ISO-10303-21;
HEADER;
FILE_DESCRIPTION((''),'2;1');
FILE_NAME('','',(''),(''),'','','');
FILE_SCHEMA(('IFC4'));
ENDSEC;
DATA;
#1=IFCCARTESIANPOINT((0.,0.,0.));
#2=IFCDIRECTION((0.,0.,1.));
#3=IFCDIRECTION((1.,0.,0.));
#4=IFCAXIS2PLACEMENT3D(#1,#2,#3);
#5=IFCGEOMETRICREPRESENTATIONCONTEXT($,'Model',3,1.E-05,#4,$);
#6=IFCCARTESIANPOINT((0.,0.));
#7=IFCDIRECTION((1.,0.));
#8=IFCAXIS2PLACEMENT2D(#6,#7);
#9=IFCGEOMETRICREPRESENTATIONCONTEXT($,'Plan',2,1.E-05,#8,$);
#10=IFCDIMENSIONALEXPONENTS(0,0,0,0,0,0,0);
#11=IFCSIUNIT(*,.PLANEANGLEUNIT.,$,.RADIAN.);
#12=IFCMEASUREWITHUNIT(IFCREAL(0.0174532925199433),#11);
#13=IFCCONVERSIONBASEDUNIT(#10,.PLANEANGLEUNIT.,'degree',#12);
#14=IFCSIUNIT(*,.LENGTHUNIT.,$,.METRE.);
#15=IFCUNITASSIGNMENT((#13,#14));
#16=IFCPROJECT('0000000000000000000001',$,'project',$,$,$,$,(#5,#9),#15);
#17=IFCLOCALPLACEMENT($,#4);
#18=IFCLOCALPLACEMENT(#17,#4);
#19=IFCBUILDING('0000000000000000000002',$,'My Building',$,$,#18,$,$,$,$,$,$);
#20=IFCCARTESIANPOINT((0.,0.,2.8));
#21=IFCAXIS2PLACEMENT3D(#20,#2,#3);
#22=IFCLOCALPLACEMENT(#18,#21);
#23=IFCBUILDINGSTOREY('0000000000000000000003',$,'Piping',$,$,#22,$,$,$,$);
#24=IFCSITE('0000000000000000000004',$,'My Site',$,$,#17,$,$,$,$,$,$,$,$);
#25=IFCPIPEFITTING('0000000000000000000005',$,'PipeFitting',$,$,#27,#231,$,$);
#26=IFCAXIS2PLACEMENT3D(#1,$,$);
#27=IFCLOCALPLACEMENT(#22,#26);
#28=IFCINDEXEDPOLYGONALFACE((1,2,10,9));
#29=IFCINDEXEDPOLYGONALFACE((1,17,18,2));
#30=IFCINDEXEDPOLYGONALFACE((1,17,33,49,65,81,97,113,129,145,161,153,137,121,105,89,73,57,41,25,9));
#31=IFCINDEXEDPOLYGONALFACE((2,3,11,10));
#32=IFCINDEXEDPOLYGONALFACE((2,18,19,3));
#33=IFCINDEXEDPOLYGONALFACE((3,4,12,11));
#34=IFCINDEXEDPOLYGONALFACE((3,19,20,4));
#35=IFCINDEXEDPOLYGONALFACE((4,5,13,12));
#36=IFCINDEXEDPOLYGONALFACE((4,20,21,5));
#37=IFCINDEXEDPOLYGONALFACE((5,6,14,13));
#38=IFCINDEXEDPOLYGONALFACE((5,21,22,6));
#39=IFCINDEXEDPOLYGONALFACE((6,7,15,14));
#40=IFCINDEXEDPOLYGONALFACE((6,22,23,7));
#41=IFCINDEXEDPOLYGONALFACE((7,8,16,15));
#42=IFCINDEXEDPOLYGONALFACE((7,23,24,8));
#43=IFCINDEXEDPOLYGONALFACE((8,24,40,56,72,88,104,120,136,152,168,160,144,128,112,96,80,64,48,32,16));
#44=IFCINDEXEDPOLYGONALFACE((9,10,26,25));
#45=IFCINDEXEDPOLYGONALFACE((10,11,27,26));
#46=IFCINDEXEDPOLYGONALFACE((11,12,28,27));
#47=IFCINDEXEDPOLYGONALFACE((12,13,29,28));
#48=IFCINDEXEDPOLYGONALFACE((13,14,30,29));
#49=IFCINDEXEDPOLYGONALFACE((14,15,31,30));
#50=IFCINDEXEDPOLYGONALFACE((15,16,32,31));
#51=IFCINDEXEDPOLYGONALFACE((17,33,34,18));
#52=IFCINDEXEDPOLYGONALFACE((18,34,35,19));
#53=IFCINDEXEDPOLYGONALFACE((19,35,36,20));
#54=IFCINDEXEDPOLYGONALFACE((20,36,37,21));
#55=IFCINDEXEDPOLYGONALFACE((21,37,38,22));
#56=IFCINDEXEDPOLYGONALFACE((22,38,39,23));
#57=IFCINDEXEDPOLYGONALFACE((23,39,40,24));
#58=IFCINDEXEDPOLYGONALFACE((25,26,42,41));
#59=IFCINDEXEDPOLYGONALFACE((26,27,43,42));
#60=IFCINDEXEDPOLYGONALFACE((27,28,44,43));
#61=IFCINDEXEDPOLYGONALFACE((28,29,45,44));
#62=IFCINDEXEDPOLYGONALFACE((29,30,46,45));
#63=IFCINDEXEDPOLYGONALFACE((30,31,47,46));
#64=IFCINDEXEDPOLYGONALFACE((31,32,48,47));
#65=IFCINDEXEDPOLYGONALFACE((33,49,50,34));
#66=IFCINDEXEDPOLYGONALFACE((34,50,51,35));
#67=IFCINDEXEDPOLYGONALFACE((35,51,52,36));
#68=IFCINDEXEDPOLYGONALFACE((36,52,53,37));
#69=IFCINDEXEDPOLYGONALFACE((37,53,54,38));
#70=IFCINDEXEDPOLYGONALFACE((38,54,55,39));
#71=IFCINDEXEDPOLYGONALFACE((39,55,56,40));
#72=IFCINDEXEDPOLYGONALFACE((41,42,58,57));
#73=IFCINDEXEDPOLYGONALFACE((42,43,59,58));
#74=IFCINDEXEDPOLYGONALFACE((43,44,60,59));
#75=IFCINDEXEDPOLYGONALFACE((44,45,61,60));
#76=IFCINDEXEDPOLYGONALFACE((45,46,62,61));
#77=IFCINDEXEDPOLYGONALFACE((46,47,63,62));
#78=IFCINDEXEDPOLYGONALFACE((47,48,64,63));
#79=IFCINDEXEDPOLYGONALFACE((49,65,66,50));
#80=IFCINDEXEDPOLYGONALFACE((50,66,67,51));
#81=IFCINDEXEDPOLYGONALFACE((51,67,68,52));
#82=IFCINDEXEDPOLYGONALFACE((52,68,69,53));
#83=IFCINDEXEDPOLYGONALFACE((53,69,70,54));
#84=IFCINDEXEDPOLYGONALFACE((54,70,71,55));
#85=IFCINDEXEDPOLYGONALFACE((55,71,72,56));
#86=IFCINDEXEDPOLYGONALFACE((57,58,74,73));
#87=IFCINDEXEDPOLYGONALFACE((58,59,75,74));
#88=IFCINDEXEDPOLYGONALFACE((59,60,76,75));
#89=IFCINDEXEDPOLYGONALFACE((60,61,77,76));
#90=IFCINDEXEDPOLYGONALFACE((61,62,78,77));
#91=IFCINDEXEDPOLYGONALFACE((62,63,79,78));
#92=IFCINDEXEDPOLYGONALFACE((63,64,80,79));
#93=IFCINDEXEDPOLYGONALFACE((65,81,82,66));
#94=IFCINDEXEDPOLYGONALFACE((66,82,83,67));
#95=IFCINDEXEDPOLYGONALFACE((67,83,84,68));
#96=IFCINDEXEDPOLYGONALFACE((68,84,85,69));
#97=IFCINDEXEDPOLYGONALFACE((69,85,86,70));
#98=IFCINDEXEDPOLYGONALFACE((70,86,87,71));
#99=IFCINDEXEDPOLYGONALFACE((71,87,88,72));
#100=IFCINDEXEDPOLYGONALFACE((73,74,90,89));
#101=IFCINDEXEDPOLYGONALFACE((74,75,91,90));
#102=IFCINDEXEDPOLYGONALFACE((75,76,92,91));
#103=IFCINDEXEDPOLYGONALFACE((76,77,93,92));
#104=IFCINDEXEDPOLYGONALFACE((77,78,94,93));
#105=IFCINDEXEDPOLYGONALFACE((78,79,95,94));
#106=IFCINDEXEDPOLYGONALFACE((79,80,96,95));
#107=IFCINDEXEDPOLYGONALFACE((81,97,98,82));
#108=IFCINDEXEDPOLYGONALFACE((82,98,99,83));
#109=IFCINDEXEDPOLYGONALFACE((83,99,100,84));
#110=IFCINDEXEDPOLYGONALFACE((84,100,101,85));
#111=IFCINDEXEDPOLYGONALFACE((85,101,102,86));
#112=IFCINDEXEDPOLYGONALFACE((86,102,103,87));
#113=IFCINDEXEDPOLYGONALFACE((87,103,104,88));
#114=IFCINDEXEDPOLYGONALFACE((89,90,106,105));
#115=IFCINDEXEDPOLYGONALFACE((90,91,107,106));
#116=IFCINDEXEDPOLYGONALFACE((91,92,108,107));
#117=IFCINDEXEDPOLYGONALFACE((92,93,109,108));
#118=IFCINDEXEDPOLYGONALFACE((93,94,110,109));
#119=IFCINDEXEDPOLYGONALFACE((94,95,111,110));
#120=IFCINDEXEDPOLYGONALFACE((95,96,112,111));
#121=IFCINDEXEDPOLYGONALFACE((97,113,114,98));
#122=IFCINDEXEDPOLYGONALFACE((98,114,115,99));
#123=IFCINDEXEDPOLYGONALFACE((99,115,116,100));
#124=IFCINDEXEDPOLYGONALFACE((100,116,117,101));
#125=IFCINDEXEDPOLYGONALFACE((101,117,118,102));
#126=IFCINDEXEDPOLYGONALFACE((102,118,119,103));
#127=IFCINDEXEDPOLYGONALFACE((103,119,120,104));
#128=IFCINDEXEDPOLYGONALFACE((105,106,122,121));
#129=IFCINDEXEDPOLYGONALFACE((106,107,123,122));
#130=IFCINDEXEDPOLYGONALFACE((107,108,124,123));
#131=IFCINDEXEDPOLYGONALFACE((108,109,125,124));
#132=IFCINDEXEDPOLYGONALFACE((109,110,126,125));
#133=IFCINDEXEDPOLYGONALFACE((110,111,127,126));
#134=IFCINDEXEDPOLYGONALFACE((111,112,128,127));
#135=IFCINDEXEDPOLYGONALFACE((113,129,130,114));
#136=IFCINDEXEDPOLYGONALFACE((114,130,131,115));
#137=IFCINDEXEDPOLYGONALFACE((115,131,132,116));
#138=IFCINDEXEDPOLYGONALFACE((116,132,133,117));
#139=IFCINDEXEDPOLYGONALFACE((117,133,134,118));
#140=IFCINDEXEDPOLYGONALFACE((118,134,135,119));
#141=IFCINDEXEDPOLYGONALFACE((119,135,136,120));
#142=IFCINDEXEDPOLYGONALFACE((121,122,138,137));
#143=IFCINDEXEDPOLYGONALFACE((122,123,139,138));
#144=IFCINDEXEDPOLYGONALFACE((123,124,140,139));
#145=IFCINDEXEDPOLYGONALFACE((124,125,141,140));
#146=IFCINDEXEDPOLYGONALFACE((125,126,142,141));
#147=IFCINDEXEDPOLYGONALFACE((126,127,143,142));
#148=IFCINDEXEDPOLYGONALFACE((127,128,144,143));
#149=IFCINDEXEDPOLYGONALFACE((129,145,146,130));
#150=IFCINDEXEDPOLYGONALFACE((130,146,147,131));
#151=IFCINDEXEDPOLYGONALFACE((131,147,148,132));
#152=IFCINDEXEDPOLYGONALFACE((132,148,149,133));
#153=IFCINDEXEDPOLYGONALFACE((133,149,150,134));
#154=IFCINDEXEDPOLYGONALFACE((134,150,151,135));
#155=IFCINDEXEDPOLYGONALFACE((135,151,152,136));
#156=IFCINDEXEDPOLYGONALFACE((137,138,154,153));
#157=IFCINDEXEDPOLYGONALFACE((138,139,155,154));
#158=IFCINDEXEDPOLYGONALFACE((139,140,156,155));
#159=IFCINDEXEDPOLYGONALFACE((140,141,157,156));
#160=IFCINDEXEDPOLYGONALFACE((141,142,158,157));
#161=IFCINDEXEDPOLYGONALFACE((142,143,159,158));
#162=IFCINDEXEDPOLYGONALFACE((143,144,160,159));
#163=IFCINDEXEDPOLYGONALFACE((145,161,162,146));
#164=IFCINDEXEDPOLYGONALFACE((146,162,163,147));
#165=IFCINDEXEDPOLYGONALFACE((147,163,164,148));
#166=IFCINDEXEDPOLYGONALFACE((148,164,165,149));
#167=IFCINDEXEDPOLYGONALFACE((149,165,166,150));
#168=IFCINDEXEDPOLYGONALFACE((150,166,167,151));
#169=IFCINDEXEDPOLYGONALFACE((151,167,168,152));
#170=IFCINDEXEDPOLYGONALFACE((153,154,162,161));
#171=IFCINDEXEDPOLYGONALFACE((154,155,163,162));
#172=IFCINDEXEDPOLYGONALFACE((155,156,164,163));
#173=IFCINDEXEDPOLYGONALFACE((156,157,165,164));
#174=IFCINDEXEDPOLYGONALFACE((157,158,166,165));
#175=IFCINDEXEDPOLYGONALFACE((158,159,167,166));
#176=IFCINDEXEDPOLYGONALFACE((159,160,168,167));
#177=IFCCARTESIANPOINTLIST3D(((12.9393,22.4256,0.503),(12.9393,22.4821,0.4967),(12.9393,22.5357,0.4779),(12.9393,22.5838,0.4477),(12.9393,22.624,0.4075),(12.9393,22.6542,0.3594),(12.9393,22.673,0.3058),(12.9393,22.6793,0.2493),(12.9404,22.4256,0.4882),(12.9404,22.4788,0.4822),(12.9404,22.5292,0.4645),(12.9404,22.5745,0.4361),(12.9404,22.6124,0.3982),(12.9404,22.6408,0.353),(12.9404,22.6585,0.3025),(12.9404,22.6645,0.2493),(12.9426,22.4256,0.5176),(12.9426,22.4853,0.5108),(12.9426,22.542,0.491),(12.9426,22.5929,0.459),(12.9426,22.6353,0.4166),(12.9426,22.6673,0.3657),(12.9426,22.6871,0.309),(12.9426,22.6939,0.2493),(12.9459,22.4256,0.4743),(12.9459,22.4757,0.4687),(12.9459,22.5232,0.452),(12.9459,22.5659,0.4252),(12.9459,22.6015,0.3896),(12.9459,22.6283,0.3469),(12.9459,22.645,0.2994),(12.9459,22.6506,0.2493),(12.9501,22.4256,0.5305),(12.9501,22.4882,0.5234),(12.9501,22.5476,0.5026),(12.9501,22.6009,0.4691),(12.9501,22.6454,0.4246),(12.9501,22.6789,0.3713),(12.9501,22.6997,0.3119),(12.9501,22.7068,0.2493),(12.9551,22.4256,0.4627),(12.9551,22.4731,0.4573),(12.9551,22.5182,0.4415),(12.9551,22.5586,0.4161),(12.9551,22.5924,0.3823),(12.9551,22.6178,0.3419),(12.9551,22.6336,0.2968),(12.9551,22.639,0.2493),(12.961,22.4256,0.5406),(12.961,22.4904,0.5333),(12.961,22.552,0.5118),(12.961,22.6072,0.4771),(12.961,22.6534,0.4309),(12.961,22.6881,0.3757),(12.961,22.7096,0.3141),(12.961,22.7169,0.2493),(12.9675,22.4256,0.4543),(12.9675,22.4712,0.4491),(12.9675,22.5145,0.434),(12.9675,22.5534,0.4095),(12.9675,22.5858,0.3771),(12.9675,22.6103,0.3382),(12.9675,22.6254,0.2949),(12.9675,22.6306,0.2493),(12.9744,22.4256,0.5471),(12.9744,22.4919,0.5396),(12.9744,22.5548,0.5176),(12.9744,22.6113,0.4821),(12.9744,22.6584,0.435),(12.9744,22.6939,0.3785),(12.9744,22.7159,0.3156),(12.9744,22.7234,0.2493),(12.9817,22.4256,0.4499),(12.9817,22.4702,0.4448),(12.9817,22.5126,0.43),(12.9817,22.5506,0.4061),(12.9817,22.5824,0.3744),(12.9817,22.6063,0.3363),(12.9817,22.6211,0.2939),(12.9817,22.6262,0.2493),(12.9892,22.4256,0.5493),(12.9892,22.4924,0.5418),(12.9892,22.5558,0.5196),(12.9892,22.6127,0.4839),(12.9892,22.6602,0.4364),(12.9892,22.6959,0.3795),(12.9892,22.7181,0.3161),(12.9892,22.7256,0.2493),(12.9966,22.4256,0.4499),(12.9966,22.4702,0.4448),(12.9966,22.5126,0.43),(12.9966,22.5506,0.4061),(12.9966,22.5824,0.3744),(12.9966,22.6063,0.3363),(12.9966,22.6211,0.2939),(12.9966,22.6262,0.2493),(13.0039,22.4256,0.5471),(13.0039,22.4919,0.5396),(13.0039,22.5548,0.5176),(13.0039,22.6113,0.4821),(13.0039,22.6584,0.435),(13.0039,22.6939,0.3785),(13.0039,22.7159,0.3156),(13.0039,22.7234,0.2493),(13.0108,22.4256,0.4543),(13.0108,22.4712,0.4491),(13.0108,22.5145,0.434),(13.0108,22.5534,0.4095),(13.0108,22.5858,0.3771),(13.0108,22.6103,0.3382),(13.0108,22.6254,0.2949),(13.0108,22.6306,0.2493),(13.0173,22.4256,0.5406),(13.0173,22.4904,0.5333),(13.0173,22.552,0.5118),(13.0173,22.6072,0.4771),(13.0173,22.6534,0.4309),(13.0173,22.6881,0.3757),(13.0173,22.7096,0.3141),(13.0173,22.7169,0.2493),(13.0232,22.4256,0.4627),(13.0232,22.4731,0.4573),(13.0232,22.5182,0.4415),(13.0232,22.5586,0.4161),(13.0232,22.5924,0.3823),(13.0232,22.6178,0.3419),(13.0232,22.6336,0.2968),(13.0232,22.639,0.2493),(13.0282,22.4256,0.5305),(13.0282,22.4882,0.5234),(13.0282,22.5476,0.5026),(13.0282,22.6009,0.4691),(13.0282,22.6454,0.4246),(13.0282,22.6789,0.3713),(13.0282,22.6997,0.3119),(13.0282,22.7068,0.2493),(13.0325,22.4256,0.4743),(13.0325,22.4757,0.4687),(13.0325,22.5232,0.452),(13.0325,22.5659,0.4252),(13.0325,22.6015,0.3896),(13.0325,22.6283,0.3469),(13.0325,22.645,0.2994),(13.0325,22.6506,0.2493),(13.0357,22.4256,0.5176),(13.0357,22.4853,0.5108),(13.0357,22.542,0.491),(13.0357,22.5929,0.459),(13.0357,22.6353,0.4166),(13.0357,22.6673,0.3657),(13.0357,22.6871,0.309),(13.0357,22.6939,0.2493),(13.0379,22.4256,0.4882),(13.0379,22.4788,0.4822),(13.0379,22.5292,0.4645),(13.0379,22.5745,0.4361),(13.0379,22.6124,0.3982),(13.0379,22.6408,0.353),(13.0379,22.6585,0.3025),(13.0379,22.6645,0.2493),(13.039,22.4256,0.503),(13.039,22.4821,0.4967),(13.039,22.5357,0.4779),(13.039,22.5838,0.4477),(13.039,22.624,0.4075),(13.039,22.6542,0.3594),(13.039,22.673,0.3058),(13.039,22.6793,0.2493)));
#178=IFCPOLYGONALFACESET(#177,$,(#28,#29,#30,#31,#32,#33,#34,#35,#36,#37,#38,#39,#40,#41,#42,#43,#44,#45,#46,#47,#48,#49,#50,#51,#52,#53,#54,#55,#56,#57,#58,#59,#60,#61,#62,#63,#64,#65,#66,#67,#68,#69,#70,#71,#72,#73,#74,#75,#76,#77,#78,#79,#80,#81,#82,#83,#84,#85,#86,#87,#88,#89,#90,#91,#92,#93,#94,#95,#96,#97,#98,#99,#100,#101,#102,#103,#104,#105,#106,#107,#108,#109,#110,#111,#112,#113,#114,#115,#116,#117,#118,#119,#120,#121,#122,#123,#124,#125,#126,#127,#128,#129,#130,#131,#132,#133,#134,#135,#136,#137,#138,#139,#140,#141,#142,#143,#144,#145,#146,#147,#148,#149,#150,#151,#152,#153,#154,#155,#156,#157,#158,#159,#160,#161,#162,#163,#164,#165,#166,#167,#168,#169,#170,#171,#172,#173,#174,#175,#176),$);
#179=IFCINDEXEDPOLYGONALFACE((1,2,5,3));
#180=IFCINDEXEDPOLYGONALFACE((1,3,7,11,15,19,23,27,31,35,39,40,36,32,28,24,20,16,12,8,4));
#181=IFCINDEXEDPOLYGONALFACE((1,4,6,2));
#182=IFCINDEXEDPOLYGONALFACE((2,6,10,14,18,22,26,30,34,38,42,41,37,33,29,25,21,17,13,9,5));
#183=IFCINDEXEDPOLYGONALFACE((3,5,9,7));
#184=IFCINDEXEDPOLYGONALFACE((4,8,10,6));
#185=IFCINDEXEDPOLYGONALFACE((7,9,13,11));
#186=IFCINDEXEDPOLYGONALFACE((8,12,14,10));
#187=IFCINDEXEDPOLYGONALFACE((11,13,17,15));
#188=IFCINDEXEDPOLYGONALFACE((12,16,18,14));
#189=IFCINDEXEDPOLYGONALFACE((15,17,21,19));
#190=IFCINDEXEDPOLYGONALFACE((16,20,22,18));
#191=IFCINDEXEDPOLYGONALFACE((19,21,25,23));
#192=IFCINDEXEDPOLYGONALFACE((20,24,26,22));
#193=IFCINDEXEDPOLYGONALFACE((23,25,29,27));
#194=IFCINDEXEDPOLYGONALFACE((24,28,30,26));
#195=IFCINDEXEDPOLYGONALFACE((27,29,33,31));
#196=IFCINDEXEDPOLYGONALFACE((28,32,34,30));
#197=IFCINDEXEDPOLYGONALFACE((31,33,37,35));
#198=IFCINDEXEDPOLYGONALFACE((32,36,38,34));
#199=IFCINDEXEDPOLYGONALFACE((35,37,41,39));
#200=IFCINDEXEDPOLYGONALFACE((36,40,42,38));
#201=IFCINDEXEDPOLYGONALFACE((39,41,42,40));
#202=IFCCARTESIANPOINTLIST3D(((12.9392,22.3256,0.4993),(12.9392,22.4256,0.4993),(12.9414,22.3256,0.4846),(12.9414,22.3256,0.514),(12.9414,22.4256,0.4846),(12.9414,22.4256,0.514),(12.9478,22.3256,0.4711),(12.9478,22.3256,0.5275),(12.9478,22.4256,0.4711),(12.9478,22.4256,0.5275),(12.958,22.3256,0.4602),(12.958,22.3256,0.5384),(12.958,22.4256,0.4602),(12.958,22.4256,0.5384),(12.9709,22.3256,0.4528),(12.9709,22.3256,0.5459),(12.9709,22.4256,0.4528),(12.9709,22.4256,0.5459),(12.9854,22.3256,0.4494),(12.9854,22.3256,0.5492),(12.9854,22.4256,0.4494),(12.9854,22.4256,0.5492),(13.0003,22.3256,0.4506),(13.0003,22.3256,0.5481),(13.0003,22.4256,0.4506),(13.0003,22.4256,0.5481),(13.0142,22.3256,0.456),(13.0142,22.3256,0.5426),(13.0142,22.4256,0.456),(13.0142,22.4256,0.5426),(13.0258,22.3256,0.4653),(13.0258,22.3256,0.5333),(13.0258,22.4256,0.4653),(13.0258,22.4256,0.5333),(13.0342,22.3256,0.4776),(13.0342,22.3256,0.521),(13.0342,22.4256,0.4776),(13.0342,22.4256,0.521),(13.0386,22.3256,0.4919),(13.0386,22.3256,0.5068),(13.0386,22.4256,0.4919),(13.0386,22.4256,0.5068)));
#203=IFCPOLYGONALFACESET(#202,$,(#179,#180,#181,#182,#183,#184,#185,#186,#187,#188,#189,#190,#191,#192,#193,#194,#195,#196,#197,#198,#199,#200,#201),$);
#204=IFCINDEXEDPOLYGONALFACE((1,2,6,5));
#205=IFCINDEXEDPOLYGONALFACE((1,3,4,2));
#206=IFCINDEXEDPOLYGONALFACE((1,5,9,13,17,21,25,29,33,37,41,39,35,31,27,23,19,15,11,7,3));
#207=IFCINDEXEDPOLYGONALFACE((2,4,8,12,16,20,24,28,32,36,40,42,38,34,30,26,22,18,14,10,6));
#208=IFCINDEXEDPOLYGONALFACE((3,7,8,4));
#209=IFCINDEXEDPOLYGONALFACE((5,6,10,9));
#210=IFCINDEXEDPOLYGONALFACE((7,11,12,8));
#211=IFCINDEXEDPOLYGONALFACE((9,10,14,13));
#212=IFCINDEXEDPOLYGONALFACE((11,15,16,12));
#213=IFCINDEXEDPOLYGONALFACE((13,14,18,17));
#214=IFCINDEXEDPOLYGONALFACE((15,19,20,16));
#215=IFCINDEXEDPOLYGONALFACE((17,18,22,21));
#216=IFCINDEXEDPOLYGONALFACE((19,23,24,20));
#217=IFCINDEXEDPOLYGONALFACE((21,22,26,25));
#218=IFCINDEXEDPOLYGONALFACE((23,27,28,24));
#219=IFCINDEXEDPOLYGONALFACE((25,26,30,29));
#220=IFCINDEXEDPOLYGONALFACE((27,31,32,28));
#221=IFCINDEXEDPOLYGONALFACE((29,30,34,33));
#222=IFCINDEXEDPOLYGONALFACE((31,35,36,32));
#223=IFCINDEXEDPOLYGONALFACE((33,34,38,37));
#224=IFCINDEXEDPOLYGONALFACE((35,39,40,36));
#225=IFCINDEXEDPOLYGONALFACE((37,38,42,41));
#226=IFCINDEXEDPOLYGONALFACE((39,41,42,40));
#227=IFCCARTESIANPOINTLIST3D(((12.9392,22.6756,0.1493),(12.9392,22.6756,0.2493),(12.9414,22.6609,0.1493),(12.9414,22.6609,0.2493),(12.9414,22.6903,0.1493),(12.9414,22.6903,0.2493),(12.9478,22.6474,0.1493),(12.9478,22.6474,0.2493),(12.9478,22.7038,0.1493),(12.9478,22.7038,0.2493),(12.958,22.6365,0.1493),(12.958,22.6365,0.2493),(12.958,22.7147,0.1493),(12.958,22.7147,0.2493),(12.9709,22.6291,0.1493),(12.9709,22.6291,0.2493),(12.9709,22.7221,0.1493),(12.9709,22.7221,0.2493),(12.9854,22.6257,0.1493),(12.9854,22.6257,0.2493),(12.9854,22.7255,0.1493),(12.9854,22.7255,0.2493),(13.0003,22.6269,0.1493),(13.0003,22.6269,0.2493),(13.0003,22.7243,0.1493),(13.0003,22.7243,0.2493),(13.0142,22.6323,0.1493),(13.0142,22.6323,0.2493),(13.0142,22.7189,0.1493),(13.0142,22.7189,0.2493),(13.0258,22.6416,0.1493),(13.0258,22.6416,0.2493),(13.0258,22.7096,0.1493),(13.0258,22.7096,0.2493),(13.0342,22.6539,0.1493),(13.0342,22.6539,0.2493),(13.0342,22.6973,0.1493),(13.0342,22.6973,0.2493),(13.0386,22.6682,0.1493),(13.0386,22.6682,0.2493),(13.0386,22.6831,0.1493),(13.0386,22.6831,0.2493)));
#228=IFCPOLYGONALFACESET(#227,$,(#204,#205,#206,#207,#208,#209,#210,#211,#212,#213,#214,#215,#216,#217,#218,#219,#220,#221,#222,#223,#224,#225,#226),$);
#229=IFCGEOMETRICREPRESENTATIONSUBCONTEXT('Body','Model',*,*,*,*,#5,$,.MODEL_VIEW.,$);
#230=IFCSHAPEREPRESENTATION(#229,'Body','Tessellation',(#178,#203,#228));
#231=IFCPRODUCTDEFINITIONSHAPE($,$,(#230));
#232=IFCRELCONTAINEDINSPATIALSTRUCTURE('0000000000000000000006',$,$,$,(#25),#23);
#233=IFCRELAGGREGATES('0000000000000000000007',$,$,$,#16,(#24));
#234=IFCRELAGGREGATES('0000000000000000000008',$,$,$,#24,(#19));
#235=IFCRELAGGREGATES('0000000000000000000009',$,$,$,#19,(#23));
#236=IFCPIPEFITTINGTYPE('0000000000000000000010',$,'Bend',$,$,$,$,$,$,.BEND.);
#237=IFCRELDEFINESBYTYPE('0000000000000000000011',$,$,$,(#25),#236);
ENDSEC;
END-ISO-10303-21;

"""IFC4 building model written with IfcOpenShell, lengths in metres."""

from ifc_helpers import new_model, entity, si_unit, converted_unit, frame, origin_with_axes, origin_2d_with_axis, place, context, subcontext, project, spatial, circle, extrude, source, transform, mapped, type_object, type_shapes, element, save


model = new_model("IFC4")

# Units and contexts
model_context = context("Model", 3, precision=1e-05, world=origin_with_axes())
plan_context = context("Plan", 2, precision=1e-05, world=origin_2d_with_axis())
body_context = subcontext(model_context, "Body", "Model", "MODEL_VIEW")
ifc_project = project(units=[converted_unit("PLANEANGLEUNIT", "degree", entity("IfcReal", 0.0174532925199433), si_unit("PLANEANGLEUNIT", "RADIAN"), dimensions=[0, 0, 0, 0, 0, 0, 0]), si_unit("LENGTHUNIT", "METRE")], contexts=[model_context, plan_context])

# Site, building, storey
site_placement = place(None, origin_with_axes())
site = spatial("IfcSite", under=ifc_project, at=site_placement, Name="My Site")
building_placement = place(site_placement, origin_with_axes())
building = spatial("IfcBuilding", under=site, at=building_placement, Name="My Building")
storey_placement = place(building_placement, frame((0.0, 0.0, 2.8), z_axis=(0.0, 0.0, 1.0), x_axis=(1.0, 0.0, 0.0)))
storey = spatial("IfcBuildingStorey", under=building, at=storey_placement, Name="Piping")

# Pipe fitting
pipe_fitting_type_1 = type_object("IfcPipeFittingType", Name="Bend", PredefinedType="BEND")
shared_shape_1 = source(origin_with_axes(), body_context, "Body", "SolidModel", [
    entity("IfcSweptDiskSolid", entity("IfcIndexedPolyCurve", entity("IfcCartesianPointList3D", [[0.0, 0.0, 0.1], [0.0, -0.0732, 0.2768], [0.0, -0.25, 0.35]]), [entity("IfcArcIndex", [1, 2, 3])]), 0.05),
    extrude(circle(Radius=0.05), origin_with_axes(), (0.0, 0.0, 1.0), 0.1),
    extrude(circle(Radius=0.05), frame((0.0, -0.25, 0.35), z_axis=(0.0, -1.0, 0.0), x_axis=(1.0, 0.0, 0.0)), (0.0, 0.0, 1.0), 0.1),
])
type_shapes(pipe_fitting_type_1, [shared_shape_1])
for number, where, z_axis, x_axis, name in (
    (1, (12.9892, 22.3256, 0.4993), (0.0, 1.0, 0.0), (-1.0, 0.0, 0.0), "PipeFitting"),
):
    element("IfcPipeFitting", number, at=place(storey_placement, frame(where, z_axis=z_axis, x_axis=x_axis)), inside=storey, type_object=pipe_fitting_type_1, Name=name, context=body_context, shape_type="MappedRepresentation", body=[
        mapped(shared_shape_1, transform((0.0, 0.0, 0.0), x_axis=(1.0, 0.0, 0.0), y_axis=(0.0, 1.0, 0.0), z_axis=(0.0, 0.0, 1.0), scale=1.0)),
    ])

save(model, "model.ifc")
